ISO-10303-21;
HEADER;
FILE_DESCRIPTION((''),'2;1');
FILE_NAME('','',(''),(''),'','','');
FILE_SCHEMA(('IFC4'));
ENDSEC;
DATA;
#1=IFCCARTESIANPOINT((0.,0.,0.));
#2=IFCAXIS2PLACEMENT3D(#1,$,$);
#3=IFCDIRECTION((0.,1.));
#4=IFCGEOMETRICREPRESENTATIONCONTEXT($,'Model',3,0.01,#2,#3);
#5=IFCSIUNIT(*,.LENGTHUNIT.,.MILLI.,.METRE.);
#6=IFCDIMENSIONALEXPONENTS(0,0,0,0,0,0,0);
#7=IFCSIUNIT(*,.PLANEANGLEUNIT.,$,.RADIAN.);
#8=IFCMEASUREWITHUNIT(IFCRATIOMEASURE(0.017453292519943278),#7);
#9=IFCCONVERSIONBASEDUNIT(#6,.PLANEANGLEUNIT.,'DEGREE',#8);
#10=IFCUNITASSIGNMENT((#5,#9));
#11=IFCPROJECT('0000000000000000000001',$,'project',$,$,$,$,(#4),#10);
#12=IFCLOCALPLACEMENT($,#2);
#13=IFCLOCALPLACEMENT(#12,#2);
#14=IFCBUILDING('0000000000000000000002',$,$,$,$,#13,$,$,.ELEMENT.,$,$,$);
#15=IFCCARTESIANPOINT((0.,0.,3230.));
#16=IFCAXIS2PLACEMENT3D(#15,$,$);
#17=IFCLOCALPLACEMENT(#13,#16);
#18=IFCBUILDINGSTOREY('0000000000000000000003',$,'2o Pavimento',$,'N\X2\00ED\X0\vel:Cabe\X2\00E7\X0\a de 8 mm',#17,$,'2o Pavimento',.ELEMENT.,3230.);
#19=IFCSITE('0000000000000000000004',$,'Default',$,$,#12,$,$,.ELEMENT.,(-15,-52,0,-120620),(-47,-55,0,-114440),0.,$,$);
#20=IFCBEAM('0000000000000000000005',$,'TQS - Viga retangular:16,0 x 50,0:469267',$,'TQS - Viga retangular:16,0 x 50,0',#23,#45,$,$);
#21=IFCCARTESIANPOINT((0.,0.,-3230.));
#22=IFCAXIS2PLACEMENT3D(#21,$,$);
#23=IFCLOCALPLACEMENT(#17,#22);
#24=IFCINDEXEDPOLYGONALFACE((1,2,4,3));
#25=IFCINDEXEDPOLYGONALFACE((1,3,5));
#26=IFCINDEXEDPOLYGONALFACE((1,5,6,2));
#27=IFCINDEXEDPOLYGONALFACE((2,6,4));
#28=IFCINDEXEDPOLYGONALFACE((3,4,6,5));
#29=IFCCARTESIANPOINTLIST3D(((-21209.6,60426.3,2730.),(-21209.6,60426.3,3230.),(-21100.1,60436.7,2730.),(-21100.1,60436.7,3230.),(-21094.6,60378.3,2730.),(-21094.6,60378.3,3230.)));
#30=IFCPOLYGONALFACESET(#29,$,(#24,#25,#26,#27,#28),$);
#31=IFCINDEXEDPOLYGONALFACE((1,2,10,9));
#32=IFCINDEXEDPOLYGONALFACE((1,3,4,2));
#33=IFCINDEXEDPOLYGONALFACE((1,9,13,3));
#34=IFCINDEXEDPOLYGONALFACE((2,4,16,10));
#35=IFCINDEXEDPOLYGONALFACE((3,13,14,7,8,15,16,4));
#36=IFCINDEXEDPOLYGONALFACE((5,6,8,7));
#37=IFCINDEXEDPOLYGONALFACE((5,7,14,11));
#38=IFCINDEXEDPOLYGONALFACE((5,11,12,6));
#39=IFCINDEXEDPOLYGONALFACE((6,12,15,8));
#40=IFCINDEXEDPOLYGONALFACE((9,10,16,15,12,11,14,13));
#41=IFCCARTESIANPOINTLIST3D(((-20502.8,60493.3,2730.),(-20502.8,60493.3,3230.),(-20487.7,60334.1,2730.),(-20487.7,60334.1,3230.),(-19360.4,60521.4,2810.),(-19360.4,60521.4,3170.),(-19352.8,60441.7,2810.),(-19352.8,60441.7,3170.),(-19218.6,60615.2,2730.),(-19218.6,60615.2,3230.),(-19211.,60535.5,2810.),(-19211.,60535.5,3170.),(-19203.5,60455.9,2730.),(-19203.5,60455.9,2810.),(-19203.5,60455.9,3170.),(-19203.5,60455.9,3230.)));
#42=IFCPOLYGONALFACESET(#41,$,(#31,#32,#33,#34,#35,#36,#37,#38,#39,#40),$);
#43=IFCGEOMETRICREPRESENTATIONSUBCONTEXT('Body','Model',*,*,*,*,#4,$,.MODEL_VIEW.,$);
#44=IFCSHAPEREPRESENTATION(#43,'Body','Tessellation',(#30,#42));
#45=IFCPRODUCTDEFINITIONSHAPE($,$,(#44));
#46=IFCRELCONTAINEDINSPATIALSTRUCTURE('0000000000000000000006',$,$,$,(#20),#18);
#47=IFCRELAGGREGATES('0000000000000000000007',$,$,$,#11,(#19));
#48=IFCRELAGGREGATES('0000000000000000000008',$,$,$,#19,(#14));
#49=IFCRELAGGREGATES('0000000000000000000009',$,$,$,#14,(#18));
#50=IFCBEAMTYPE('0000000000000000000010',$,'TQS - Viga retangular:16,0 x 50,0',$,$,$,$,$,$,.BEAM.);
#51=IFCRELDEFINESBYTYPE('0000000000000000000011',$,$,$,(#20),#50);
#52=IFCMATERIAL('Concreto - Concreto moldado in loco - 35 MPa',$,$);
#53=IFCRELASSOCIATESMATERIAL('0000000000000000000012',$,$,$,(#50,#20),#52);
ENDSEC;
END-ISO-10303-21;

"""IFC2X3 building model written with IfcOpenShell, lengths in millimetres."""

from ifc_helpers import new_model, entity, si_unit, converted_unit, direction, frame, frame_2d, origin, place, context, subcontext, project, spatial, polyline, rectangle, extrude, boolean, clip, halfspace, bounded_halfspace, source, transform, mapped, material, type_object, type_shapes, element, save


model = new_model("IFC2X3")

# Units and contexts
model_context = context("Model", 3, precision=0.01, world=origin(), true_north=direction((0.0, 1.0)))
body_context = subcontext(model_context, "Body", "Model", "MODEL_VIEW")
ifc_project = project(units=[si_unit("LENGTHUNIT", "METRE", prefix="MILLI"), converted_unit("PLANEANGLEUNIT", "DEGREE", entity("IfcRatioMeasure", 0.017453292519943278), si_unit("PLANEANGLEUNIT", "RADIAN"), dimensions=[0, 0, 0, 0, 0, 0, 0])], contexts=[model_context])

# Site, building, storey
site_placement = place(None, origin())
site = spatial("IfcSite", under=ifc_project, at=site_placement, Name="Default", CompositionType="ELEMENT", RefLatitude=(-15, -52, 0, -120620), RefLongitude=(-47, -55, 0, -114440), RefElevation=0.0)
building_placement = place(site_placement, origin())
building = spatial("IfcBuilding", under=site, at=building_placement, CompositionType="ELEMENT")
storey_placement = place(building_placement, frame((0.0, 0.0, 3230.0)))
storey = spatial("IfcBuildingStorey", under=building, at=storey_placement, Name="2o Pavimento", ObjectType="Nível:Cabeça de 8 mm", LongName="2o Pavimento", CompositionType="ELEMENT", Elevation=3230.0)

# Shared definitions
ifc_material = material(Name="Concreto - Concreto moldado in loco - 35 MPa")

# Beam
beam_type_1 = type_object("IfcBeamType", Name="TQS - Viga retangular:16,0 x 50,0", PredefinedType="BEAM", material=ifc_material)
shared_shape_1 = source(origin(), body_context, "Body", "SweptSolid", [
    clip(extrude(rectangle(XDim=500.0, YDim=58.7, at=frame_2d((0.0, 0.0), x_axis=(1.0, 0.0))), frame((-21097.4, 60407.5, 2980.0), z_axis=(-0.995529, -0.094456, 0.0), x_axis=(0.0, 0.0, -1.0)), (0.0, 0.0, 1.0), 110.0), halfspace(frame((-20895.9, 60295.3, 3230.0), z_axis=(-0.385141, -0.922858, 0.0), x_axis=(0.922858, -0.385141, 0.0)), False)),
    boolean("DIFFERENCE", clip(extrude(rectangle(XDim=500.0, YDim=160.0, at=frame_2d((0.0, 0.0), x_axis=(1.0, 0.0))), frame((-19211.0, 60535.5, 2980.0), z_axis=(-0.995529, -0.094456, 0.0), x_axis=(0.0, 0.0, -1.0)), (0.0, 0.0, 1.0), 1290.0), bounded_halfspace(frame((-19360.4, 60521.4, 2810.0), z_axis=(0.995529, 0.094456, 0.0), x_axis=(0.094456, -0.995529, 0.0)), False, frame((-19211.0, 60535.5, 2980.0), z_axis=(-0.995529, -0.094456, 0.0), x_axis=(0.0, 0.0, -1.0)), polyline([(170.0, 0.0), (-190.0, 0.0), (-190.0, 80.0), (-90.0, 80.0), (170.0, 80.0), (170.0, 0.0)]))), extrude(rectangle(XDim=360.0, YDim=80.0, at=frame_2d((0.0, 0.0), x_axis=(0.0, 1.0))), frame((-19207.3, 60495.7, 2990.0), z_axis=(0.995529, 0.094456, 0.0), x_axis=(-0.094456, 0.995529, 0.0)), (0.0, 0.0, -1.0), 150.0)),
])
type_shapes(beam_type_1, [shared_shape_1])
beam_1_placement = place(storey_placement, frame((0.0, 0.0, -3230.0)))
element("IfcBeam", 1, at=beam_1_placement, inside=storey, type_object=beam_type_1, material=ifc_material, Name="TQS - Viga retangular:16,0 x 50,0:469267", ObjectType="TQS - Viga retangular:16,0 x 50,0", context=body_context, shape_type="MappedRepresentation", body=[
    mapped(shared_shape_1, transform((0.0, 0.0, 0.0), scale=1.0)),
])

save(model, "model.ifc")
